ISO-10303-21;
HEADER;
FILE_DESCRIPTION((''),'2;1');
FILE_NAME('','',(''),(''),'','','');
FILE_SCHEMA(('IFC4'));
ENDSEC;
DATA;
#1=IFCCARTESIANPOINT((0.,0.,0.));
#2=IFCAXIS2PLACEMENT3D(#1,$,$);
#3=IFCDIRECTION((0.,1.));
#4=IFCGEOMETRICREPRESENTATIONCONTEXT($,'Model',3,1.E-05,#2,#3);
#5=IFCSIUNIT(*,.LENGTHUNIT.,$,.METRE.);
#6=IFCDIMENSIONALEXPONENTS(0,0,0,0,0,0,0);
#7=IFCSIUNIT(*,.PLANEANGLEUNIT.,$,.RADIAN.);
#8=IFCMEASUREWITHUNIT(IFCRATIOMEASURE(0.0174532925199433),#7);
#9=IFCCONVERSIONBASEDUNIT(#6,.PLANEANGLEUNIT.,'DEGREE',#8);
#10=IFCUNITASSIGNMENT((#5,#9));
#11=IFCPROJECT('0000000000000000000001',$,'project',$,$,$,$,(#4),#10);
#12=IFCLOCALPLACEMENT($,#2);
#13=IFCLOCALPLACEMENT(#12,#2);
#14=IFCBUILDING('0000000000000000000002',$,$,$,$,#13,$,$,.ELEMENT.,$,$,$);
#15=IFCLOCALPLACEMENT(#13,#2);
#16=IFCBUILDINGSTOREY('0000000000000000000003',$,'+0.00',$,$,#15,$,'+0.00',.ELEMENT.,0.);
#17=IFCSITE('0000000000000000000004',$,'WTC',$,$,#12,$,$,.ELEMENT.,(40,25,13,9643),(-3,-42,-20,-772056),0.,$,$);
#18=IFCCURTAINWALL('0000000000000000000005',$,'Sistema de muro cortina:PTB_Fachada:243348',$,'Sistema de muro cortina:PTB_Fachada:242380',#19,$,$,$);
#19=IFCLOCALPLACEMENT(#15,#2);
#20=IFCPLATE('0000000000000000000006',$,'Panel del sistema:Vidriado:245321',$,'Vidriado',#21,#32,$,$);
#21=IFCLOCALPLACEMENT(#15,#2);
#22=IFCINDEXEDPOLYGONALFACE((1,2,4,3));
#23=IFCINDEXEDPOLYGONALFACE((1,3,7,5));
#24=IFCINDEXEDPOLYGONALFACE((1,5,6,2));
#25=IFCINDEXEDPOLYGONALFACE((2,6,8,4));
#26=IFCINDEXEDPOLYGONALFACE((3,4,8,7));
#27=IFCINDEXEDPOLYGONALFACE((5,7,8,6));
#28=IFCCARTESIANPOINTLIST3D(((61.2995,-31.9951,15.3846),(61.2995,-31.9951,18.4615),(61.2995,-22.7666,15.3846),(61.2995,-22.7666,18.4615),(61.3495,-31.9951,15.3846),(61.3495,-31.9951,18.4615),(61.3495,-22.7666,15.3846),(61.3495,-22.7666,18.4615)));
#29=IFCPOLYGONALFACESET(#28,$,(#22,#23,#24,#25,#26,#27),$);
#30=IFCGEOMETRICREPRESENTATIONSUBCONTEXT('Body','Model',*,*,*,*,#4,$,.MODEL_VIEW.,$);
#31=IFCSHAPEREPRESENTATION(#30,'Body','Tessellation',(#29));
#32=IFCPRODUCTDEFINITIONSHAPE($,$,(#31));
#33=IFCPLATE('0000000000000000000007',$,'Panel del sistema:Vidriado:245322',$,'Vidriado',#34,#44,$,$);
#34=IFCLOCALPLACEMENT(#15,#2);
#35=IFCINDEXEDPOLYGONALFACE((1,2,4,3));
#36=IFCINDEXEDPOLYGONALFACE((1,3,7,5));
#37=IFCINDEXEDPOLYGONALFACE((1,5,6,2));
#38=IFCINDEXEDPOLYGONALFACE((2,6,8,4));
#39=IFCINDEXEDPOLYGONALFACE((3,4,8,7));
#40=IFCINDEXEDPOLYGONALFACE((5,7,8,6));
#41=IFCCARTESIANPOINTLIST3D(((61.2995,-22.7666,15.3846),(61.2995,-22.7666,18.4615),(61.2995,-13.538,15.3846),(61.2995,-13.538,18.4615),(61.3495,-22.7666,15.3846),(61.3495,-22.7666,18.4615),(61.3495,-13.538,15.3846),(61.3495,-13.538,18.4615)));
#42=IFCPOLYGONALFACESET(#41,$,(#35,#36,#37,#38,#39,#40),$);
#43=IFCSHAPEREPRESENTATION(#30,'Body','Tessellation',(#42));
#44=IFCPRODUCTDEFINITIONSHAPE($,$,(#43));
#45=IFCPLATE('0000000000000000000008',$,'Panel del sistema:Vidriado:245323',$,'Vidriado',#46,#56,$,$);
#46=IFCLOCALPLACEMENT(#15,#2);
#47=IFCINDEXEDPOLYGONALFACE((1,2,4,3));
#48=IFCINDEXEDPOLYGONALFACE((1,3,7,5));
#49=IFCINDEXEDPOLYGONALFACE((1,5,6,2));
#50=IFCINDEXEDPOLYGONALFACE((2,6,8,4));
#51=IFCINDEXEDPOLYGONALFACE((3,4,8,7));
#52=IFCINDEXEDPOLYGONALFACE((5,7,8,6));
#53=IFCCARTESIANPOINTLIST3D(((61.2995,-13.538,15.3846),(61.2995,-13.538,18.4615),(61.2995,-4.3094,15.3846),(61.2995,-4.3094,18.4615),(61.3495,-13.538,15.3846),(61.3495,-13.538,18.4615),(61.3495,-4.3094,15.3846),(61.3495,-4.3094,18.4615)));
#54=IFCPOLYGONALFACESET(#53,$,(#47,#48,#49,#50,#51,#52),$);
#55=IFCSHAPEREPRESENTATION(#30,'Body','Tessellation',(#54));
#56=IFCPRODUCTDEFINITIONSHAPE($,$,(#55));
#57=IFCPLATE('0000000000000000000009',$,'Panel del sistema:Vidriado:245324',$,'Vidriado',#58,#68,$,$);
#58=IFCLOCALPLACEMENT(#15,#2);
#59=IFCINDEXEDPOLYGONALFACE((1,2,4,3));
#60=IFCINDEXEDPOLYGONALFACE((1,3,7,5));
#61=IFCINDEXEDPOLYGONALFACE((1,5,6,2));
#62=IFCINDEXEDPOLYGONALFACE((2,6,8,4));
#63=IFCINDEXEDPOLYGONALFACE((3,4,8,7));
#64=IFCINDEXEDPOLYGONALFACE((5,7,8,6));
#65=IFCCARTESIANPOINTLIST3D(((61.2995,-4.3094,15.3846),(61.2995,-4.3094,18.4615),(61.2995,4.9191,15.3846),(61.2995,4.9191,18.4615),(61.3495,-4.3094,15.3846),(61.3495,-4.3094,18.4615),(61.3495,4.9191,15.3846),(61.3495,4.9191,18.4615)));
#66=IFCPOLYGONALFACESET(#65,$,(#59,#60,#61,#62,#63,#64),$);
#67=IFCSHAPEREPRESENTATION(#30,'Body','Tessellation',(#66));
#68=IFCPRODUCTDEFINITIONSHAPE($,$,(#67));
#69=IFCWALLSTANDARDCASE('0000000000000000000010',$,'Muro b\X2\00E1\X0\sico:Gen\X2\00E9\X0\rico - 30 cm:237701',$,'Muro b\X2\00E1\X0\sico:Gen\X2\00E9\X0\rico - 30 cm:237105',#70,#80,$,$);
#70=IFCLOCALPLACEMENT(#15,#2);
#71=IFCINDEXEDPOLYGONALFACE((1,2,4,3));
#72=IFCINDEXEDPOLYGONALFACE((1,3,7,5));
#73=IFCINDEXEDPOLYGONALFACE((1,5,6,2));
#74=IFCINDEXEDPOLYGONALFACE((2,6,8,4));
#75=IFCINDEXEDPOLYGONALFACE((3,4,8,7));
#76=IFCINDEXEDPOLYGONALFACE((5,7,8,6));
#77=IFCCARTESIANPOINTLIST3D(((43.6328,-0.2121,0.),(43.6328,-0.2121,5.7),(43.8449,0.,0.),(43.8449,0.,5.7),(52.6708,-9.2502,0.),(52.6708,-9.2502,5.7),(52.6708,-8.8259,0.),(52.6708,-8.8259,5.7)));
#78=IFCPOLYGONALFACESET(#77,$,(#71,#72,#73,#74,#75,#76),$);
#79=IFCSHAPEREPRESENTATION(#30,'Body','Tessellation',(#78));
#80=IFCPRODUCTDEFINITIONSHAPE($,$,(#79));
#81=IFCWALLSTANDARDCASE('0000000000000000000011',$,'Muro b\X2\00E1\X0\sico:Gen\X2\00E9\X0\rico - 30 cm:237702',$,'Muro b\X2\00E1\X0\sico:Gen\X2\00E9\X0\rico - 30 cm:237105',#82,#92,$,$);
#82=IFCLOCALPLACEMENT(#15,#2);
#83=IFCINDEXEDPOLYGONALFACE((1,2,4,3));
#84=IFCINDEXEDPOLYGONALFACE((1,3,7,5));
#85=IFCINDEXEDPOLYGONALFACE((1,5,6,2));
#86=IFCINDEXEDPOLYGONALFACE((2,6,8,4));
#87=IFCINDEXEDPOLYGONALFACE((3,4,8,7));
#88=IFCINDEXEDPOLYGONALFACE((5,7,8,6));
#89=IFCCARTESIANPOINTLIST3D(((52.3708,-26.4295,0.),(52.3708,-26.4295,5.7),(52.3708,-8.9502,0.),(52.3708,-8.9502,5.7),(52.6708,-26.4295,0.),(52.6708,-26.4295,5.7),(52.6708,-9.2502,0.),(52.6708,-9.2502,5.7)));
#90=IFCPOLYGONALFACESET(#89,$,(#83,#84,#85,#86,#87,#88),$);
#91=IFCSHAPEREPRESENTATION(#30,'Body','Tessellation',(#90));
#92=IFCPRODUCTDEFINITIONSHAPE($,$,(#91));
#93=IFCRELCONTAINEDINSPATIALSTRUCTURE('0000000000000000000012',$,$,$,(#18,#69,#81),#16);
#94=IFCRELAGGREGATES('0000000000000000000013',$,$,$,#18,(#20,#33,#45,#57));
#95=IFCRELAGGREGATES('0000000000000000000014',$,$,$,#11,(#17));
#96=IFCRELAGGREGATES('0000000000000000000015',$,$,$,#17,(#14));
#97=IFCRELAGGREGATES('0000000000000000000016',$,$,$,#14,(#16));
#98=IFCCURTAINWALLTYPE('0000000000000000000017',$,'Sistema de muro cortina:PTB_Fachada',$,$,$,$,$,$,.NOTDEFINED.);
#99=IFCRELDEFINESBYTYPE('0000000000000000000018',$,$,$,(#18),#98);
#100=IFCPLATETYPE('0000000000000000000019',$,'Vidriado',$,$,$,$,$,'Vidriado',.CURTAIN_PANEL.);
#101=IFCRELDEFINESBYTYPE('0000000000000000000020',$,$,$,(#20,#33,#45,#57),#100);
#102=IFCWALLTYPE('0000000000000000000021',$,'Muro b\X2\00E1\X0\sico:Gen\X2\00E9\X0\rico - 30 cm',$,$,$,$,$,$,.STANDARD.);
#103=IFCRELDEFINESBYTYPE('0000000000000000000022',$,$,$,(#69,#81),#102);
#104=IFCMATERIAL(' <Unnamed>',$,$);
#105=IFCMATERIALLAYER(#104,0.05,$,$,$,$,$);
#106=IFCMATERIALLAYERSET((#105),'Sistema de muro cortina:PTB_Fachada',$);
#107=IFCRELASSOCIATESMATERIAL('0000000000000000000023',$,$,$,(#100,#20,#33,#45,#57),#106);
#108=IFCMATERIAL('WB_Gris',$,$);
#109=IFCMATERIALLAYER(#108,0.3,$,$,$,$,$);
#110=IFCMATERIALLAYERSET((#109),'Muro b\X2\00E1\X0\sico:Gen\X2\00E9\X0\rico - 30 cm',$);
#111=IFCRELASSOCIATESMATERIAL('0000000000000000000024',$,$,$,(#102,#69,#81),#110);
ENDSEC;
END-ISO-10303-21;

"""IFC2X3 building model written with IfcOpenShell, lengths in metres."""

from ifc_helpers import new_model, entity, si_unit, converted_unit, direction, frame, origin, origin_2d_with_axis, place, context, subcontext, project, spatial, polyline, rectangle, outline, extrude, clip, bounded_halfspace, source, transform, mapped, material, layer, layer_set, layer_usage, type_object, type_shapes, element, aggregate, save


model = new_model("IFC2X3")

# Units and contexts
model_context = context("Model", 3, precision=1e-05, world=origin(), true_north=direction((0.0, 1.0)))
body_context = subcontext(model_context, "Body", "Model", "MODEL_VIEW")
ifc_project = project(units=[si_unit("LENGTHUNIT", "METRE"), converted_unit("PLANEANGLEUNIT", "DEGREE", entity("IfcRatioMeasure", 0.0174532925199433), si_unit("PLANEANGLEUNIT", "RADIAN"), dimensions=[0, 0, 0, 0, 0, 0, 0])], contexts=[model_context])

# Site, building, storey
site_placement = place(None, origin())
site = spatial("IfcSite", under=ifc_project, at=site_placement, Name="WTC", CompositionType="ELEMENT", RefLatitude=(40, 25, 13, 9643), RefLongitude=(-3, -42, -20, -772056), RefElevation=0.0)
building_placement = place(site_placement, origin())
building = spatial("IfcBuilding", under=site, at=building_placement, CompositionType="ELEMENT")
storey_placement = place(building_placement, origin())
storey = spatial("IfcBuildingStorey", under=building, at=storey_placement, Name="+0.00", LongName="+0.00", CompositionType="ELEMENT", Elevation=0.0)

# Curtain wall, plates
curtain_wall_type = type_object("IfcCurtainWallType", Name="Sistema de muro cortina:PTB_Fachada", PredefinedType="NOTDEFINED")
ifc_material_1 = material(Name=" <Unnamed>")
ifc_layer_1 = layer(ifc_material_1, 0.05)
ifc_layer_set_1 = layer_set([ifc_layer_1], Name="Sistema de muro cortina:PTB_Fachada")
curtain_wall_1_placement = place(storey_placement, origin())
curtain_wall_1 = element("IfcCurtainWall", 1, at=curtain_wall_1_placement, inside=storey, type_object=curtain_wall_type, Name="Sistema de muro cortina:PTB_Fachada:243348", ObjectType="Sistema de muro cortina:PTB_Fachada:242380")
plate_type_1 = type_object("IfcPlateType", Name="Vidriado", ElementType="Vidriado", PredefinedType="CURTAIN_PANEL", material=ifc_layer_set_1)
shared_shape_1 = source(origin(), body_context, "Body", "SweptSolid", [
    extrude(rectangle(XDim=0.05, YDim=9.2286, at=origin_2d_with_axis()), frame((0.0, 0.0, 0.0), z_axis=(0.0, 0.0, 1.0), x_axis=(0.0, 1.0, 0.0)), (0.0, 0.0, 1.0), 3.0769),
])
type_shapes(plate_type_1, [shared_shape_1])
ifc_layer_usage_1 = layer_usage(ifc_layer_set_1, "AXIS3", "POSITIVE", 0.0)
plate_1_placement = place(curtain_wall_1_placement, frame((61.3245, -27.3809, 15.3846), z_axis=(0.0, 0.0, 1.0), x_axis=(0.0, 1.0, 0.0)))
plate_1 = element("IfcPlate", 2, at=plate_1_placement, type_object=plate_type_1, material=ifc_layer_usage_1, Name="Panel del sistema:Vidriado:245321", ObjectType="Vidriado", context=body_context, shape_type="MappedRepresentation", body=[
    mapped(shared_shape_1, transform((0.0, 0.0, 0.0), scale=1.0)),
])
ifc_layer_usage_2 = layer_usage(ifc_layer_set_1, "AXIS3", "POSITIVE", 0.0)
plate_2_placement = place(curtain_wall_1_placement, frame((61.3245, -18.1523, 15.3846), z_axis=(0.0, 0.0, 1.0), x_axis=(0.0, 1.0, 0.0)))
plate_2 = element("IfcPlate", 3, at=plate_2_placement, type_object=plate_type_1, material=ifc_layer_usage_2, Name="Panel del sistema:Vidriado:245322", ObjectType="Vidriado", context=body_context, shape_type="MappedRepresentation", body=[
    mapped(shared_shape_1, transform((0.0, 0.0, 0.0), scale=1.0)),
])
ifc_layer_usage_3 = layer_usage(ifc_layer_set_1, "AXIS3", "POSITIVE", 0.0)
plate_3_placement = place(curtain_wall_1_placement, frame((61.3245, -8.9237, 15.3846), z_axis=(0.0, 0.0, 1.0), x_axis=(0.0, 1.0, 0.0)))
plate_3 = element("IfcPlate", 4, at=plate_3_placement, type_object=plate_type_1, material=ifc_layer_usage_3, Name="Panel del sistema:Vidriado:245323", ObjectType="Vidriado", context=body_context, shape_type="MappedRepresentation", body=[
    mapped(shared_shape_1, transform((0.0, 0.0, 0.0), scale=1.0)),
])
ifc_layer_usage_4 = layer_usage(ifc_layer_set_1, "AXIS3", "POSITIVE", 0.0)
plate_4_placement = place(curtain_wall_1_placement, frame((61.3245, 0.3049, 15.3846), z_axis=(0.0, 0.0, 1.0), x_axis=(0.0, 1.0, 0.0)))
plate_4 = element("IfcPlate", 5, at=plate_4_placement, type_object=plate_type_1, material=ifc_layer_usage_4, Name="Panel del sistema:Vidriado:245324", ObjectType="Vidriado", context=body_context, shape_type="MappedRepresentation", body=[
    mapped(shared_shape_1, transform((0.0, 0.0, 0.0), scale=1.0)),
])
aggregate(curtain_wall_1, [plate_1, plate_2, plate_3, plate_4])

# Walls
ifc_material_2 = material(Name="WB_Gris")
ifc_layer_2 = layer(ifc_material_2, 0.3)
ifc_layer_set_2 = layer_set([ifc_layer_2], Name="Muro básico:Genérico - 30 cm")
ifc_layer_usage_5 = layer_usage(ifc_layer_set_2, "AXIS2", "NEGATIVE", 0.15)
wall_type = type_object("IfcWallType", Name="Muro básico:Genérico - 30 cm", PredefinedType="STANDARD", material=ifc_layer_set_2)
wall_1_placement = place(storey_placement, frame((52.7769, -9.1441, 0.0), z_axis=(0.0, 0.0, 1.0), x_axis=(-0.707107, 0.707107, 0.0)))
element("IfcWallStandardCase", 6, at=wall_1_placement, inside=storey, type_object=wall_type, material=ifc_layer_usage_5, Name="Muro básico:Genérico - 30 cm:237701", ObjectType="Muro básico:Genérico - 30 cm:237105", context=body_context, shape_type="Clipping", body=[
    clip(extrude(outline(polyline([(12.7817, -0.15), (12.7817, 0.15), (0.4243, 0.15), (0.0, 0.15), (0.3, -0.15), (12.7817, -0.15)])), origin(), (0.0, 0.0, 1.0), 5.7), bounded_halfspace(frame((0.3, -0.15, 5.7), z_axis=(0.0, 0.0, 1.0), x_axis=(0.707107, -0.707107, 0.0)), False, frame((0.3, -0.15, 5.7), z_axis=(0.0, 0.0, 1.0), x_axis=(0.707107, -0.707107, 0.0)), polyline([(0.0, 0.0), (8.8259, 8.8259), (8.6138, 9.038), (-0.1243, 0.3), (-0.4243, 0.0), (0.0, 0.0)]))),
])
ifc_layer_usage_6 = layer_usage(ifc_layer_set_2, "AXIS2", "NEGATIVE", 0.15)
wall_2_placement = place(storey_placement, frame((52.5208, -26.4295, 0.0), z_axis=(0.0, 0.0, 1.0), x_axis=(0.0, 1.0, 0.0)))
element("IfcWallStandardCase", 7, at=wall_2_placement, inside=storey, type_object=wall_type, material=ifc_layer_usage_6, Name="Muro básico:Genérico - 30 cm:237702", ObjectType="Muro básico:Genérico - 30 cm:237105", context=body_context, shape_type="Clipping", body=[
    clip(extrude(outline(polyline([(17.1793, -0.15), (17.4793, 0.15), (0.3, 0.15), (0.0, 0.15), (0.0, -0.15), (17.1793, -0.15)])), origin(), (0.0, 0.0, 1.0), 5.7), bounded_halfspace(frame((0.0, -0.15, 5.7)), False, frame((0.0, -0.15, 5.7)), polyline([(0.0, 0.0), (17.1793, 0.0), (17.4793, 0.3), (0.3, 0.3), (0.0, 0.3), (0.0, 0.0)]))),
])

save(model, "model.ifc")
